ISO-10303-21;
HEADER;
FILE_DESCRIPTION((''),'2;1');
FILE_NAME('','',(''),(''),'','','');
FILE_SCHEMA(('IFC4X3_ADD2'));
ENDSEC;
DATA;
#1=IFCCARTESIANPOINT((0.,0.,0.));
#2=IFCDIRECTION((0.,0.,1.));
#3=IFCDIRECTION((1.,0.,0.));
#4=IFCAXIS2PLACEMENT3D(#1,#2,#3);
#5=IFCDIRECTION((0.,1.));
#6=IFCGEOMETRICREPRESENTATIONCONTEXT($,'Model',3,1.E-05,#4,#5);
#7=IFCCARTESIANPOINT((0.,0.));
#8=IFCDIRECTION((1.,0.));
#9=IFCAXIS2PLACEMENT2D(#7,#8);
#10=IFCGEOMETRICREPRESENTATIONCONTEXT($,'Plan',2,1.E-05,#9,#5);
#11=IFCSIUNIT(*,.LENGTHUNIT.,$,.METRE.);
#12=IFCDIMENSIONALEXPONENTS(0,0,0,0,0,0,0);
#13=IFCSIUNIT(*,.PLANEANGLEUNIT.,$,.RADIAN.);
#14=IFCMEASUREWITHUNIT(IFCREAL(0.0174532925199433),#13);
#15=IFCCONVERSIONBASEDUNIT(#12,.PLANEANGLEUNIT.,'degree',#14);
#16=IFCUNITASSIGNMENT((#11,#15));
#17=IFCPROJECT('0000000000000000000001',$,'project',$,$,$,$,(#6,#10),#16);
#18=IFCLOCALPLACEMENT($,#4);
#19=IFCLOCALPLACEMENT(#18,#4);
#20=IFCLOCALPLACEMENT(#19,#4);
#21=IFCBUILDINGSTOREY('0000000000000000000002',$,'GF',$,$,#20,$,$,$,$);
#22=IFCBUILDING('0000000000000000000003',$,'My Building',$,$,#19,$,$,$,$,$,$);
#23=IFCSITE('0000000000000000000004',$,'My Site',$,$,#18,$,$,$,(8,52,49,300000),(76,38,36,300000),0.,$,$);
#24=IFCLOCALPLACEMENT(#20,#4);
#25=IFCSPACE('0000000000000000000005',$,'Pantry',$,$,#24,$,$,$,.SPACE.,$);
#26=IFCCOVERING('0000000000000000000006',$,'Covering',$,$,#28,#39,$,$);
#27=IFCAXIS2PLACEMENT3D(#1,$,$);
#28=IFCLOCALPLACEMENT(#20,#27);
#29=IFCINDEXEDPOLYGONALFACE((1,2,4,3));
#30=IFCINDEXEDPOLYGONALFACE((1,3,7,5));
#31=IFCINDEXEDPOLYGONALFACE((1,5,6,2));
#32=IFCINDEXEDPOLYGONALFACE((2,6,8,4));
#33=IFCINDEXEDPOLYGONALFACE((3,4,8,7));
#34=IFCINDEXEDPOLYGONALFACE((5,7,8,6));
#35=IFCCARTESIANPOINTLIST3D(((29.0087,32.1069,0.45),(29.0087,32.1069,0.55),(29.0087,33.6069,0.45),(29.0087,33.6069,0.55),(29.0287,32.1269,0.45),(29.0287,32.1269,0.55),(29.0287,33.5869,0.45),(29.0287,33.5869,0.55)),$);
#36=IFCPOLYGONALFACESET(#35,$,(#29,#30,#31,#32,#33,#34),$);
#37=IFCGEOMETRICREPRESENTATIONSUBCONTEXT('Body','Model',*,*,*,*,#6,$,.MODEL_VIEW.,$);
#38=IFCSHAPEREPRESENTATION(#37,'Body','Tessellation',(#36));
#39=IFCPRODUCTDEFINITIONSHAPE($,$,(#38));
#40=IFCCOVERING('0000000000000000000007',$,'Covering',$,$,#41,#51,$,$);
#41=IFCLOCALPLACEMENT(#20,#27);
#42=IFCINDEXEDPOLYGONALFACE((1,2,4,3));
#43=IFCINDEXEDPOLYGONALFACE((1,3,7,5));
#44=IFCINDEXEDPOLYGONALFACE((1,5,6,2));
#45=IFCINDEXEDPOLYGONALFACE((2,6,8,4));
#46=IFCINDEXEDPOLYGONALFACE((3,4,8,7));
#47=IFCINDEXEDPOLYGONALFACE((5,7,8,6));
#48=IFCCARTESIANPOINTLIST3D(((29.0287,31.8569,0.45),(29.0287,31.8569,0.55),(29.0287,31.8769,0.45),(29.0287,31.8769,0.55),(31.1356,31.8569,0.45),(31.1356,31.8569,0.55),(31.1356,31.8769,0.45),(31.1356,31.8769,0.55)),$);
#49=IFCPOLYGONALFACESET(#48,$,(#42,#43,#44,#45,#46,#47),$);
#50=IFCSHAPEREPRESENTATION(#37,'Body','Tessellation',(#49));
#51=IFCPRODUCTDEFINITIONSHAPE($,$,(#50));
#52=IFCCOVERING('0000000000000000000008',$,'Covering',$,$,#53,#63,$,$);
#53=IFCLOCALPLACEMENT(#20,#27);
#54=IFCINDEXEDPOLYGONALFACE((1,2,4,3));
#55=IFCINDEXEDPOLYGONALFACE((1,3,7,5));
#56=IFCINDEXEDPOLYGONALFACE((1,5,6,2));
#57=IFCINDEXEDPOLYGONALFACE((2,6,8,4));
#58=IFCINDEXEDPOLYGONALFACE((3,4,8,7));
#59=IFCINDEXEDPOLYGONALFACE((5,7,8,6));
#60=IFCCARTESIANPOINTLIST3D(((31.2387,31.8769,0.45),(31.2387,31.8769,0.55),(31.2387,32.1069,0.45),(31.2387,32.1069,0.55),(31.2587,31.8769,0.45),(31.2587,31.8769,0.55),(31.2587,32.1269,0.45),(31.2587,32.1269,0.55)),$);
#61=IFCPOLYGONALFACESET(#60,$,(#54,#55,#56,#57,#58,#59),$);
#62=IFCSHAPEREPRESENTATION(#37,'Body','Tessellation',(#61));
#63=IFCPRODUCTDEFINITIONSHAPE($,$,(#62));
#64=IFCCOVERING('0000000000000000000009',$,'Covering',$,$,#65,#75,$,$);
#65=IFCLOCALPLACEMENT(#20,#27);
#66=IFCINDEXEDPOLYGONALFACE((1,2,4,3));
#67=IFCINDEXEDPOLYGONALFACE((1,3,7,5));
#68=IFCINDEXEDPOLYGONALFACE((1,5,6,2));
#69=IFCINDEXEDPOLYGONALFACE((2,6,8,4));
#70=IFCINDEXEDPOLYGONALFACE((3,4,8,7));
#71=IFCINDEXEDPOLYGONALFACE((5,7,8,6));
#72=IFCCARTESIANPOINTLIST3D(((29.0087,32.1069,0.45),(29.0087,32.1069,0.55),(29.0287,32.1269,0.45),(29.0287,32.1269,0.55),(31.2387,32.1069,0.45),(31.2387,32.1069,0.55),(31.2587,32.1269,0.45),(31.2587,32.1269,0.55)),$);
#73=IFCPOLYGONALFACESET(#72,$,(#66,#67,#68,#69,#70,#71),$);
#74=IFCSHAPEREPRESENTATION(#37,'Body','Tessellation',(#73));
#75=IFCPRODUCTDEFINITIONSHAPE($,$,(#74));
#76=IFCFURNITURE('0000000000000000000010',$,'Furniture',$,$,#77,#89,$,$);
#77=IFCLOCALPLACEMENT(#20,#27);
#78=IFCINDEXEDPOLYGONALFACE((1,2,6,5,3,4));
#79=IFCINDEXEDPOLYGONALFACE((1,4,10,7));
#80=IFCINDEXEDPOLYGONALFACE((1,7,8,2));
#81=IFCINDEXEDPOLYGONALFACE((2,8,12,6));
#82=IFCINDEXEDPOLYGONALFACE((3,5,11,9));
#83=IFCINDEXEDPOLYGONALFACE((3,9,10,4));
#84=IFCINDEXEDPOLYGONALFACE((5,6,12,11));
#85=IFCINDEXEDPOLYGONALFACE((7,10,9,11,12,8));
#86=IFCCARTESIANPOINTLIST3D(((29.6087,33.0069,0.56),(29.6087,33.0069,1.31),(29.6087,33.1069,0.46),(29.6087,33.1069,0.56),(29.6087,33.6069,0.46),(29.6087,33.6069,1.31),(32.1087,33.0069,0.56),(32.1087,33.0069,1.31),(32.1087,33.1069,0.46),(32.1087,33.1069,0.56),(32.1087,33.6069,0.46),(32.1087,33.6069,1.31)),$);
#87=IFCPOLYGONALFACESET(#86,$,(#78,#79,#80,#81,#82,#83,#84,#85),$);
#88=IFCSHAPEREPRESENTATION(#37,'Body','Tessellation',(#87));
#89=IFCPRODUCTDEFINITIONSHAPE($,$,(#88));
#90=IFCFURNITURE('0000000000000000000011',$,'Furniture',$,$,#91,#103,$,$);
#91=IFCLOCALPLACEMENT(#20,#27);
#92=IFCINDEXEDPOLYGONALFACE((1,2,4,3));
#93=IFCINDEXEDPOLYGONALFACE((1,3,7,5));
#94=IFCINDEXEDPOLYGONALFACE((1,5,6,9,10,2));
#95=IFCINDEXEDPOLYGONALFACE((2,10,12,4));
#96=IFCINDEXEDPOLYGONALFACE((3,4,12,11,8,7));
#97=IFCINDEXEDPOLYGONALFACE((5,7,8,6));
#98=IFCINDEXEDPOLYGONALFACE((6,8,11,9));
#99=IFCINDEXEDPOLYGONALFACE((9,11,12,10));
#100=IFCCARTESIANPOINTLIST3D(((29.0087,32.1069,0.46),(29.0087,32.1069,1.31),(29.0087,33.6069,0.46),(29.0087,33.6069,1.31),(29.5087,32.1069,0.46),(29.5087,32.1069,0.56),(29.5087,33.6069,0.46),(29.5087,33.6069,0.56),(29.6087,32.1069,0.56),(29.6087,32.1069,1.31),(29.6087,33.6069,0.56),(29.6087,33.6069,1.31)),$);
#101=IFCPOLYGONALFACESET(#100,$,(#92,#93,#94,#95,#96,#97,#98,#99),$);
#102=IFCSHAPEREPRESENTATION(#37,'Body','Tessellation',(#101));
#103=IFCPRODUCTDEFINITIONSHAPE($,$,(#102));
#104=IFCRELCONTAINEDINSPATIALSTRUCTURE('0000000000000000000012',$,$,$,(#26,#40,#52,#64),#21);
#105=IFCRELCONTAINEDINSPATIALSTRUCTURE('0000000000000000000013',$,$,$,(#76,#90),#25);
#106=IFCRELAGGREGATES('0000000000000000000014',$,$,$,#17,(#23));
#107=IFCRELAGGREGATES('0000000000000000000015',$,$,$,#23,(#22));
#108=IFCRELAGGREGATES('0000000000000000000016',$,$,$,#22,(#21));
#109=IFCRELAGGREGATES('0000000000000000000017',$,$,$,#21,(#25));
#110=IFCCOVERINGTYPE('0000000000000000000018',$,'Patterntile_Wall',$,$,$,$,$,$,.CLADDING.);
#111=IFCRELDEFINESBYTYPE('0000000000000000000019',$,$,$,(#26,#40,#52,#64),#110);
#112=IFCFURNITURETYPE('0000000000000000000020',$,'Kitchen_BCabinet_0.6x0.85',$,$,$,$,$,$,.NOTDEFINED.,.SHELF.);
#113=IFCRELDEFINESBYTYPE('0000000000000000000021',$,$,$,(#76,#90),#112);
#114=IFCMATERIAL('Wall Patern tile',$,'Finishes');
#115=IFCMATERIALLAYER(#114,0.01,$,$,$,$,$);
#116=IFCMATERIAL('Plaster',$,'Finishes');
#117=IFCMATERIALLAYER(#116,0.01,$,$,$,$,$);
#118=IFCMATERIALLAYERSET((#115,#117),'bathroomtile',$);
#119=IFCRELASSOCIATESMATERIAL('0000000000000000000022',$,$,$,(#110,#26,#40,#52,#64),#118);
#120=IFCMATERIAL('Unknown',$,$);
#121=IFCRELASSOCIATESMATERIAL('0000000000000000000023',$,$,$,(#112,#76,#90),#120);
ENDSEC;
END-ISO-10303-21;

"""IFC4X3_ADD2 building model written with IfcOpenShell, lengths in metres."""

from ifc_helpers import new_model, entity, si_unit, converted_unit, direction, frame, origin_with_axes, origin_2d_with_axis, place, context, subcontext, project, spatial, line, indexed_curve, outline, extrude, material, layer, layer_set, layer_usage, material_profile, profile_set, profile_usage, type_object, element, save


model = new_model("IFC4X3_ADD2")

# Units and contexts
model_context = context("Model", 3, precision=1e-05, world=origin_with_axes(), true_north=direction((0.0, 1.0)))
plan_context = context("Plan", 2, precision=1e-05, world=origin_2d_with_axis(), true_north=direction((0.0, 1.0)))
body_context = subcontext(model_context, "Body", "Model", "MODEL_VIEW")
ifc_project = project(units=[si_unit("LENGTHUNIT", "METRE"), converted_unit("PLANEANGLEUNIT", "degree", entity("IfcReal", 0.0174532925199433), si_unit("PLANEANGLEUNIT", "RADIAN"), dimensions=[0, 0, 0, 0, 0, 0, 0])], contexts=[model_context, plan_context])

# Site, building, storey
site_placement = place(None, origin_with_axes())
site = spatial("IfcSite", under=ifc_project, at=site_placement, Name="My Site", RefLatitude=(8, 52, 49, 300000), RefLongitude=(76, 38, 36, 300000), RefElevation=0.0)
building_placement = place(site_placement, origin_with_axes())
building = spatial("IfcBuilding", under=site, at=building_placement, Name="My Building")
storey_placement = place(building_placement, origin_with_axes())
storey = spatial("IfcBuildingStorey", under=building, at=storey_placement, Name="GF")

# Shared definitions
ifc_material_1 = material(Name="Unknown")

# Coverings
ifc_material_2 = material(Name="Wall Patern tile", Category="Finishes")
ifc_layer_1 = layer(ifc_material_2, 0.01)
ifc_material_3 = material(Name="Plaster", Category="Finishes")
ifc_layer_2 = layer(ifc_material_3, 0.01)
ifc_layer_set_1 = layer_set([ifc_layer_1, ifc_layer_2], Name="bathroomtile")
covering_type = type_object("IfcCoveringType", Name="Patterntile_Wall", PredefinedType="CLADDING", material=ifc_layer_set_1)
ifc_layer_usage_1 = layer_usage(ifc_layer_set_1, "AXIS2", "POSITIVE", 0.0)
covering_1_placement = place(storey_placement, frame((29.0287, 32.1269, 0.45), z_axis=(0.0, 0.0, 1.0), x_axis=(0.0, 1.0, 0.0)))
element("IfcCovering", 1, at=covering_1_placement, inside=storey, type_object=covering_type, material=ifc_layer_usage_1, Name="Covering", context=body_context, shape_type="SweptSolid", body=[
    extrude(outline(indexed_curve([(0.0, 0.0), (-0.02, 0.02), (1.48, 0.02), (1.46, 0.0)], segments=[line(1, 2, 3, 4, 1)])), origin_with_axes(), (0.0, 0.0, 1.0), 0.1),
])
ifc_layer_usage_2 = layer_usage(ifc_layer_set_1, "AXIS2", "NEGATIVE", 0.0)
covering_2_placement = place(storey_placement, frame((31.1356, 31.8569, 0.45), z_axis=(0.0, 0.0, 1.0), x_axis=(-1.0, 0.000001, 0.0)))
element("IfcCovering", 2, at=covering_2_placement, inside=storey, type_object=covering_type, material=ifc_layer_usage_2, Name="Covering", context=body_context, shape_type="SweptSolid", body=[
    extrude(outline(indexed_curve([(0.0, -0.02), (0.0, 0.0), (2.1069, 0.0), (2.1069, -0.02)], segments=[line(1, 2, 3, 4, 1)])), origin_with_axes(), (0.0, 0.0, 1.0), 0.1),
])
ifc_layer_usage_3 = layer_usage(ifc_layer_set_1, "AXIS2", "POSITIVE", 0.0)
covering_3_placement = place(storey_placement, frame((31.2587, 31.8769, 0.45), z_axis=(0.0, 0.0, 1.0), x_axis=(0.000001, 1.0, 0.0)))
element("IfcCovering", 3, at=covering_3_placement, inside=storey, type_object=covering_type, material=ifc_layer_usage_3, Name="Covering", context=body_context, shape_type="SweptSolid", body=[
    extrude(outline(indexed_curve([(0.0, 0.0), (0.0, 0.02), (0.23, 0.02), (0.25, 0.0)], segments=[line(1, 2, 3, 4, 1)])), origin_with_axes(), (0.0, 0.0, 1.0), 0.1),
])
ifc_layer_usage_4 = layer_usage(ifc_layer_set_1, "AXIS2", "POSITIVE", 0.0)
covering_4_placement = place(storey_placement, frame((31.2587, 32.1269, 0.45), z_axis=(0.0, 0.0, 1.0), x_axis=(-1.0, 0.000001, 0.0)))
element("IfcCovering", 4, at=covering_4_placement, inside=storey, type_object=covering_type, material=ifc_layer_usage_4, Name="Covering", context=body_context, shape_type="SweptSolid", body=[
    extrude(outline(indexed_curve([(0.0, 0.0), (0.02, 0.02), (2.25, 0.02), (2.23, 0.0)], segments=[line(1, 2, 3, 4, 1)])), origin_with_axes(), (0.0, 0.0, 1.0), 0.1),
])

# Shared definitions
space_placement = place(storey_placement, origin_with_axes())
space = spatial("IfcSpace", under=storey, at=space_placement, Name="Pantry", PredefinedType="SPACE")

# Furniture
ifc_material_profile_1 = material_profile(ifc_material_1, outline(indexed_curve([(0.5, 0.0), (0.0, 0.0), (0.0, 0.85), (0.6, 0.85), (0.6, 0.1), (0.5, 0.1), (0.5, 0.0)])))
ifc_profile_set_1 = profile_set([ifc_material_profile_1], Name="blank")
ifc_profile_usage_1 = profile_usage(ifc_profile_set_1, cardinal=5)
furniture_type = type_object("IfcFurnitureType", Name="Kitchen_BCabinet_0.6x0.85", AssemblyPlace="NOTDEFINED", PredefinedType="SHELF", material=ifc_profile_set_1)
furniture_1_placement = place(space_placement, frame((32.1087, 33.6069, 0.46), z_axis=(-1.0, 0.0, 0.0), x_axis=(0.0, -1.0, 0.0)))
element("IfcFurniture", 5, at=furniture_1_placement, inside=space, type_object=furniture_type, material=ifc_profile_usage_1, Name="Furniture", context=body_context, shape_type="SweptSolid", body=[
    extrude(outline(indexed_curve([(0.5, 0.0), (0.0, 0.0), (0.0, 0.85), (0.6, 0.85), (0.6, 0.1), (0.5, 0.1), (0.5, 0.0)])), origin_with_axes(), (0.0, 0.0, 1.0), 2.5),
])
ifc_profile_usage_2 = profile_usage(ifc_profile_set_1, cardinal=5)
furniture_2_placement = place(space_placement, frame((29.0087, 33.6069, 0.46), z_axis=(0.0, -1.0, 0.0), x_axis=(1.0, 0.0, 0.0)))
element("IfcFurniture", 6, at=furniture_2_placement, inside=space, type_object=furniture_type, material=ifc_profile_usage_2, Name="Furniture", context=body_context, shape_type="SweptSolid", body=[
    extrude(outline(indexed_curve([(0.5, 0.0), (0.0, 0.0), (0.0, 0.85), (0.6, 0.85), (0.6, 0.1), (0.5, 0.1), (0.5, 0.0)])), origin_with_axes(), (0.0, 0.0, 1.0), 1.5),
])

save(model, "model.ifc")
